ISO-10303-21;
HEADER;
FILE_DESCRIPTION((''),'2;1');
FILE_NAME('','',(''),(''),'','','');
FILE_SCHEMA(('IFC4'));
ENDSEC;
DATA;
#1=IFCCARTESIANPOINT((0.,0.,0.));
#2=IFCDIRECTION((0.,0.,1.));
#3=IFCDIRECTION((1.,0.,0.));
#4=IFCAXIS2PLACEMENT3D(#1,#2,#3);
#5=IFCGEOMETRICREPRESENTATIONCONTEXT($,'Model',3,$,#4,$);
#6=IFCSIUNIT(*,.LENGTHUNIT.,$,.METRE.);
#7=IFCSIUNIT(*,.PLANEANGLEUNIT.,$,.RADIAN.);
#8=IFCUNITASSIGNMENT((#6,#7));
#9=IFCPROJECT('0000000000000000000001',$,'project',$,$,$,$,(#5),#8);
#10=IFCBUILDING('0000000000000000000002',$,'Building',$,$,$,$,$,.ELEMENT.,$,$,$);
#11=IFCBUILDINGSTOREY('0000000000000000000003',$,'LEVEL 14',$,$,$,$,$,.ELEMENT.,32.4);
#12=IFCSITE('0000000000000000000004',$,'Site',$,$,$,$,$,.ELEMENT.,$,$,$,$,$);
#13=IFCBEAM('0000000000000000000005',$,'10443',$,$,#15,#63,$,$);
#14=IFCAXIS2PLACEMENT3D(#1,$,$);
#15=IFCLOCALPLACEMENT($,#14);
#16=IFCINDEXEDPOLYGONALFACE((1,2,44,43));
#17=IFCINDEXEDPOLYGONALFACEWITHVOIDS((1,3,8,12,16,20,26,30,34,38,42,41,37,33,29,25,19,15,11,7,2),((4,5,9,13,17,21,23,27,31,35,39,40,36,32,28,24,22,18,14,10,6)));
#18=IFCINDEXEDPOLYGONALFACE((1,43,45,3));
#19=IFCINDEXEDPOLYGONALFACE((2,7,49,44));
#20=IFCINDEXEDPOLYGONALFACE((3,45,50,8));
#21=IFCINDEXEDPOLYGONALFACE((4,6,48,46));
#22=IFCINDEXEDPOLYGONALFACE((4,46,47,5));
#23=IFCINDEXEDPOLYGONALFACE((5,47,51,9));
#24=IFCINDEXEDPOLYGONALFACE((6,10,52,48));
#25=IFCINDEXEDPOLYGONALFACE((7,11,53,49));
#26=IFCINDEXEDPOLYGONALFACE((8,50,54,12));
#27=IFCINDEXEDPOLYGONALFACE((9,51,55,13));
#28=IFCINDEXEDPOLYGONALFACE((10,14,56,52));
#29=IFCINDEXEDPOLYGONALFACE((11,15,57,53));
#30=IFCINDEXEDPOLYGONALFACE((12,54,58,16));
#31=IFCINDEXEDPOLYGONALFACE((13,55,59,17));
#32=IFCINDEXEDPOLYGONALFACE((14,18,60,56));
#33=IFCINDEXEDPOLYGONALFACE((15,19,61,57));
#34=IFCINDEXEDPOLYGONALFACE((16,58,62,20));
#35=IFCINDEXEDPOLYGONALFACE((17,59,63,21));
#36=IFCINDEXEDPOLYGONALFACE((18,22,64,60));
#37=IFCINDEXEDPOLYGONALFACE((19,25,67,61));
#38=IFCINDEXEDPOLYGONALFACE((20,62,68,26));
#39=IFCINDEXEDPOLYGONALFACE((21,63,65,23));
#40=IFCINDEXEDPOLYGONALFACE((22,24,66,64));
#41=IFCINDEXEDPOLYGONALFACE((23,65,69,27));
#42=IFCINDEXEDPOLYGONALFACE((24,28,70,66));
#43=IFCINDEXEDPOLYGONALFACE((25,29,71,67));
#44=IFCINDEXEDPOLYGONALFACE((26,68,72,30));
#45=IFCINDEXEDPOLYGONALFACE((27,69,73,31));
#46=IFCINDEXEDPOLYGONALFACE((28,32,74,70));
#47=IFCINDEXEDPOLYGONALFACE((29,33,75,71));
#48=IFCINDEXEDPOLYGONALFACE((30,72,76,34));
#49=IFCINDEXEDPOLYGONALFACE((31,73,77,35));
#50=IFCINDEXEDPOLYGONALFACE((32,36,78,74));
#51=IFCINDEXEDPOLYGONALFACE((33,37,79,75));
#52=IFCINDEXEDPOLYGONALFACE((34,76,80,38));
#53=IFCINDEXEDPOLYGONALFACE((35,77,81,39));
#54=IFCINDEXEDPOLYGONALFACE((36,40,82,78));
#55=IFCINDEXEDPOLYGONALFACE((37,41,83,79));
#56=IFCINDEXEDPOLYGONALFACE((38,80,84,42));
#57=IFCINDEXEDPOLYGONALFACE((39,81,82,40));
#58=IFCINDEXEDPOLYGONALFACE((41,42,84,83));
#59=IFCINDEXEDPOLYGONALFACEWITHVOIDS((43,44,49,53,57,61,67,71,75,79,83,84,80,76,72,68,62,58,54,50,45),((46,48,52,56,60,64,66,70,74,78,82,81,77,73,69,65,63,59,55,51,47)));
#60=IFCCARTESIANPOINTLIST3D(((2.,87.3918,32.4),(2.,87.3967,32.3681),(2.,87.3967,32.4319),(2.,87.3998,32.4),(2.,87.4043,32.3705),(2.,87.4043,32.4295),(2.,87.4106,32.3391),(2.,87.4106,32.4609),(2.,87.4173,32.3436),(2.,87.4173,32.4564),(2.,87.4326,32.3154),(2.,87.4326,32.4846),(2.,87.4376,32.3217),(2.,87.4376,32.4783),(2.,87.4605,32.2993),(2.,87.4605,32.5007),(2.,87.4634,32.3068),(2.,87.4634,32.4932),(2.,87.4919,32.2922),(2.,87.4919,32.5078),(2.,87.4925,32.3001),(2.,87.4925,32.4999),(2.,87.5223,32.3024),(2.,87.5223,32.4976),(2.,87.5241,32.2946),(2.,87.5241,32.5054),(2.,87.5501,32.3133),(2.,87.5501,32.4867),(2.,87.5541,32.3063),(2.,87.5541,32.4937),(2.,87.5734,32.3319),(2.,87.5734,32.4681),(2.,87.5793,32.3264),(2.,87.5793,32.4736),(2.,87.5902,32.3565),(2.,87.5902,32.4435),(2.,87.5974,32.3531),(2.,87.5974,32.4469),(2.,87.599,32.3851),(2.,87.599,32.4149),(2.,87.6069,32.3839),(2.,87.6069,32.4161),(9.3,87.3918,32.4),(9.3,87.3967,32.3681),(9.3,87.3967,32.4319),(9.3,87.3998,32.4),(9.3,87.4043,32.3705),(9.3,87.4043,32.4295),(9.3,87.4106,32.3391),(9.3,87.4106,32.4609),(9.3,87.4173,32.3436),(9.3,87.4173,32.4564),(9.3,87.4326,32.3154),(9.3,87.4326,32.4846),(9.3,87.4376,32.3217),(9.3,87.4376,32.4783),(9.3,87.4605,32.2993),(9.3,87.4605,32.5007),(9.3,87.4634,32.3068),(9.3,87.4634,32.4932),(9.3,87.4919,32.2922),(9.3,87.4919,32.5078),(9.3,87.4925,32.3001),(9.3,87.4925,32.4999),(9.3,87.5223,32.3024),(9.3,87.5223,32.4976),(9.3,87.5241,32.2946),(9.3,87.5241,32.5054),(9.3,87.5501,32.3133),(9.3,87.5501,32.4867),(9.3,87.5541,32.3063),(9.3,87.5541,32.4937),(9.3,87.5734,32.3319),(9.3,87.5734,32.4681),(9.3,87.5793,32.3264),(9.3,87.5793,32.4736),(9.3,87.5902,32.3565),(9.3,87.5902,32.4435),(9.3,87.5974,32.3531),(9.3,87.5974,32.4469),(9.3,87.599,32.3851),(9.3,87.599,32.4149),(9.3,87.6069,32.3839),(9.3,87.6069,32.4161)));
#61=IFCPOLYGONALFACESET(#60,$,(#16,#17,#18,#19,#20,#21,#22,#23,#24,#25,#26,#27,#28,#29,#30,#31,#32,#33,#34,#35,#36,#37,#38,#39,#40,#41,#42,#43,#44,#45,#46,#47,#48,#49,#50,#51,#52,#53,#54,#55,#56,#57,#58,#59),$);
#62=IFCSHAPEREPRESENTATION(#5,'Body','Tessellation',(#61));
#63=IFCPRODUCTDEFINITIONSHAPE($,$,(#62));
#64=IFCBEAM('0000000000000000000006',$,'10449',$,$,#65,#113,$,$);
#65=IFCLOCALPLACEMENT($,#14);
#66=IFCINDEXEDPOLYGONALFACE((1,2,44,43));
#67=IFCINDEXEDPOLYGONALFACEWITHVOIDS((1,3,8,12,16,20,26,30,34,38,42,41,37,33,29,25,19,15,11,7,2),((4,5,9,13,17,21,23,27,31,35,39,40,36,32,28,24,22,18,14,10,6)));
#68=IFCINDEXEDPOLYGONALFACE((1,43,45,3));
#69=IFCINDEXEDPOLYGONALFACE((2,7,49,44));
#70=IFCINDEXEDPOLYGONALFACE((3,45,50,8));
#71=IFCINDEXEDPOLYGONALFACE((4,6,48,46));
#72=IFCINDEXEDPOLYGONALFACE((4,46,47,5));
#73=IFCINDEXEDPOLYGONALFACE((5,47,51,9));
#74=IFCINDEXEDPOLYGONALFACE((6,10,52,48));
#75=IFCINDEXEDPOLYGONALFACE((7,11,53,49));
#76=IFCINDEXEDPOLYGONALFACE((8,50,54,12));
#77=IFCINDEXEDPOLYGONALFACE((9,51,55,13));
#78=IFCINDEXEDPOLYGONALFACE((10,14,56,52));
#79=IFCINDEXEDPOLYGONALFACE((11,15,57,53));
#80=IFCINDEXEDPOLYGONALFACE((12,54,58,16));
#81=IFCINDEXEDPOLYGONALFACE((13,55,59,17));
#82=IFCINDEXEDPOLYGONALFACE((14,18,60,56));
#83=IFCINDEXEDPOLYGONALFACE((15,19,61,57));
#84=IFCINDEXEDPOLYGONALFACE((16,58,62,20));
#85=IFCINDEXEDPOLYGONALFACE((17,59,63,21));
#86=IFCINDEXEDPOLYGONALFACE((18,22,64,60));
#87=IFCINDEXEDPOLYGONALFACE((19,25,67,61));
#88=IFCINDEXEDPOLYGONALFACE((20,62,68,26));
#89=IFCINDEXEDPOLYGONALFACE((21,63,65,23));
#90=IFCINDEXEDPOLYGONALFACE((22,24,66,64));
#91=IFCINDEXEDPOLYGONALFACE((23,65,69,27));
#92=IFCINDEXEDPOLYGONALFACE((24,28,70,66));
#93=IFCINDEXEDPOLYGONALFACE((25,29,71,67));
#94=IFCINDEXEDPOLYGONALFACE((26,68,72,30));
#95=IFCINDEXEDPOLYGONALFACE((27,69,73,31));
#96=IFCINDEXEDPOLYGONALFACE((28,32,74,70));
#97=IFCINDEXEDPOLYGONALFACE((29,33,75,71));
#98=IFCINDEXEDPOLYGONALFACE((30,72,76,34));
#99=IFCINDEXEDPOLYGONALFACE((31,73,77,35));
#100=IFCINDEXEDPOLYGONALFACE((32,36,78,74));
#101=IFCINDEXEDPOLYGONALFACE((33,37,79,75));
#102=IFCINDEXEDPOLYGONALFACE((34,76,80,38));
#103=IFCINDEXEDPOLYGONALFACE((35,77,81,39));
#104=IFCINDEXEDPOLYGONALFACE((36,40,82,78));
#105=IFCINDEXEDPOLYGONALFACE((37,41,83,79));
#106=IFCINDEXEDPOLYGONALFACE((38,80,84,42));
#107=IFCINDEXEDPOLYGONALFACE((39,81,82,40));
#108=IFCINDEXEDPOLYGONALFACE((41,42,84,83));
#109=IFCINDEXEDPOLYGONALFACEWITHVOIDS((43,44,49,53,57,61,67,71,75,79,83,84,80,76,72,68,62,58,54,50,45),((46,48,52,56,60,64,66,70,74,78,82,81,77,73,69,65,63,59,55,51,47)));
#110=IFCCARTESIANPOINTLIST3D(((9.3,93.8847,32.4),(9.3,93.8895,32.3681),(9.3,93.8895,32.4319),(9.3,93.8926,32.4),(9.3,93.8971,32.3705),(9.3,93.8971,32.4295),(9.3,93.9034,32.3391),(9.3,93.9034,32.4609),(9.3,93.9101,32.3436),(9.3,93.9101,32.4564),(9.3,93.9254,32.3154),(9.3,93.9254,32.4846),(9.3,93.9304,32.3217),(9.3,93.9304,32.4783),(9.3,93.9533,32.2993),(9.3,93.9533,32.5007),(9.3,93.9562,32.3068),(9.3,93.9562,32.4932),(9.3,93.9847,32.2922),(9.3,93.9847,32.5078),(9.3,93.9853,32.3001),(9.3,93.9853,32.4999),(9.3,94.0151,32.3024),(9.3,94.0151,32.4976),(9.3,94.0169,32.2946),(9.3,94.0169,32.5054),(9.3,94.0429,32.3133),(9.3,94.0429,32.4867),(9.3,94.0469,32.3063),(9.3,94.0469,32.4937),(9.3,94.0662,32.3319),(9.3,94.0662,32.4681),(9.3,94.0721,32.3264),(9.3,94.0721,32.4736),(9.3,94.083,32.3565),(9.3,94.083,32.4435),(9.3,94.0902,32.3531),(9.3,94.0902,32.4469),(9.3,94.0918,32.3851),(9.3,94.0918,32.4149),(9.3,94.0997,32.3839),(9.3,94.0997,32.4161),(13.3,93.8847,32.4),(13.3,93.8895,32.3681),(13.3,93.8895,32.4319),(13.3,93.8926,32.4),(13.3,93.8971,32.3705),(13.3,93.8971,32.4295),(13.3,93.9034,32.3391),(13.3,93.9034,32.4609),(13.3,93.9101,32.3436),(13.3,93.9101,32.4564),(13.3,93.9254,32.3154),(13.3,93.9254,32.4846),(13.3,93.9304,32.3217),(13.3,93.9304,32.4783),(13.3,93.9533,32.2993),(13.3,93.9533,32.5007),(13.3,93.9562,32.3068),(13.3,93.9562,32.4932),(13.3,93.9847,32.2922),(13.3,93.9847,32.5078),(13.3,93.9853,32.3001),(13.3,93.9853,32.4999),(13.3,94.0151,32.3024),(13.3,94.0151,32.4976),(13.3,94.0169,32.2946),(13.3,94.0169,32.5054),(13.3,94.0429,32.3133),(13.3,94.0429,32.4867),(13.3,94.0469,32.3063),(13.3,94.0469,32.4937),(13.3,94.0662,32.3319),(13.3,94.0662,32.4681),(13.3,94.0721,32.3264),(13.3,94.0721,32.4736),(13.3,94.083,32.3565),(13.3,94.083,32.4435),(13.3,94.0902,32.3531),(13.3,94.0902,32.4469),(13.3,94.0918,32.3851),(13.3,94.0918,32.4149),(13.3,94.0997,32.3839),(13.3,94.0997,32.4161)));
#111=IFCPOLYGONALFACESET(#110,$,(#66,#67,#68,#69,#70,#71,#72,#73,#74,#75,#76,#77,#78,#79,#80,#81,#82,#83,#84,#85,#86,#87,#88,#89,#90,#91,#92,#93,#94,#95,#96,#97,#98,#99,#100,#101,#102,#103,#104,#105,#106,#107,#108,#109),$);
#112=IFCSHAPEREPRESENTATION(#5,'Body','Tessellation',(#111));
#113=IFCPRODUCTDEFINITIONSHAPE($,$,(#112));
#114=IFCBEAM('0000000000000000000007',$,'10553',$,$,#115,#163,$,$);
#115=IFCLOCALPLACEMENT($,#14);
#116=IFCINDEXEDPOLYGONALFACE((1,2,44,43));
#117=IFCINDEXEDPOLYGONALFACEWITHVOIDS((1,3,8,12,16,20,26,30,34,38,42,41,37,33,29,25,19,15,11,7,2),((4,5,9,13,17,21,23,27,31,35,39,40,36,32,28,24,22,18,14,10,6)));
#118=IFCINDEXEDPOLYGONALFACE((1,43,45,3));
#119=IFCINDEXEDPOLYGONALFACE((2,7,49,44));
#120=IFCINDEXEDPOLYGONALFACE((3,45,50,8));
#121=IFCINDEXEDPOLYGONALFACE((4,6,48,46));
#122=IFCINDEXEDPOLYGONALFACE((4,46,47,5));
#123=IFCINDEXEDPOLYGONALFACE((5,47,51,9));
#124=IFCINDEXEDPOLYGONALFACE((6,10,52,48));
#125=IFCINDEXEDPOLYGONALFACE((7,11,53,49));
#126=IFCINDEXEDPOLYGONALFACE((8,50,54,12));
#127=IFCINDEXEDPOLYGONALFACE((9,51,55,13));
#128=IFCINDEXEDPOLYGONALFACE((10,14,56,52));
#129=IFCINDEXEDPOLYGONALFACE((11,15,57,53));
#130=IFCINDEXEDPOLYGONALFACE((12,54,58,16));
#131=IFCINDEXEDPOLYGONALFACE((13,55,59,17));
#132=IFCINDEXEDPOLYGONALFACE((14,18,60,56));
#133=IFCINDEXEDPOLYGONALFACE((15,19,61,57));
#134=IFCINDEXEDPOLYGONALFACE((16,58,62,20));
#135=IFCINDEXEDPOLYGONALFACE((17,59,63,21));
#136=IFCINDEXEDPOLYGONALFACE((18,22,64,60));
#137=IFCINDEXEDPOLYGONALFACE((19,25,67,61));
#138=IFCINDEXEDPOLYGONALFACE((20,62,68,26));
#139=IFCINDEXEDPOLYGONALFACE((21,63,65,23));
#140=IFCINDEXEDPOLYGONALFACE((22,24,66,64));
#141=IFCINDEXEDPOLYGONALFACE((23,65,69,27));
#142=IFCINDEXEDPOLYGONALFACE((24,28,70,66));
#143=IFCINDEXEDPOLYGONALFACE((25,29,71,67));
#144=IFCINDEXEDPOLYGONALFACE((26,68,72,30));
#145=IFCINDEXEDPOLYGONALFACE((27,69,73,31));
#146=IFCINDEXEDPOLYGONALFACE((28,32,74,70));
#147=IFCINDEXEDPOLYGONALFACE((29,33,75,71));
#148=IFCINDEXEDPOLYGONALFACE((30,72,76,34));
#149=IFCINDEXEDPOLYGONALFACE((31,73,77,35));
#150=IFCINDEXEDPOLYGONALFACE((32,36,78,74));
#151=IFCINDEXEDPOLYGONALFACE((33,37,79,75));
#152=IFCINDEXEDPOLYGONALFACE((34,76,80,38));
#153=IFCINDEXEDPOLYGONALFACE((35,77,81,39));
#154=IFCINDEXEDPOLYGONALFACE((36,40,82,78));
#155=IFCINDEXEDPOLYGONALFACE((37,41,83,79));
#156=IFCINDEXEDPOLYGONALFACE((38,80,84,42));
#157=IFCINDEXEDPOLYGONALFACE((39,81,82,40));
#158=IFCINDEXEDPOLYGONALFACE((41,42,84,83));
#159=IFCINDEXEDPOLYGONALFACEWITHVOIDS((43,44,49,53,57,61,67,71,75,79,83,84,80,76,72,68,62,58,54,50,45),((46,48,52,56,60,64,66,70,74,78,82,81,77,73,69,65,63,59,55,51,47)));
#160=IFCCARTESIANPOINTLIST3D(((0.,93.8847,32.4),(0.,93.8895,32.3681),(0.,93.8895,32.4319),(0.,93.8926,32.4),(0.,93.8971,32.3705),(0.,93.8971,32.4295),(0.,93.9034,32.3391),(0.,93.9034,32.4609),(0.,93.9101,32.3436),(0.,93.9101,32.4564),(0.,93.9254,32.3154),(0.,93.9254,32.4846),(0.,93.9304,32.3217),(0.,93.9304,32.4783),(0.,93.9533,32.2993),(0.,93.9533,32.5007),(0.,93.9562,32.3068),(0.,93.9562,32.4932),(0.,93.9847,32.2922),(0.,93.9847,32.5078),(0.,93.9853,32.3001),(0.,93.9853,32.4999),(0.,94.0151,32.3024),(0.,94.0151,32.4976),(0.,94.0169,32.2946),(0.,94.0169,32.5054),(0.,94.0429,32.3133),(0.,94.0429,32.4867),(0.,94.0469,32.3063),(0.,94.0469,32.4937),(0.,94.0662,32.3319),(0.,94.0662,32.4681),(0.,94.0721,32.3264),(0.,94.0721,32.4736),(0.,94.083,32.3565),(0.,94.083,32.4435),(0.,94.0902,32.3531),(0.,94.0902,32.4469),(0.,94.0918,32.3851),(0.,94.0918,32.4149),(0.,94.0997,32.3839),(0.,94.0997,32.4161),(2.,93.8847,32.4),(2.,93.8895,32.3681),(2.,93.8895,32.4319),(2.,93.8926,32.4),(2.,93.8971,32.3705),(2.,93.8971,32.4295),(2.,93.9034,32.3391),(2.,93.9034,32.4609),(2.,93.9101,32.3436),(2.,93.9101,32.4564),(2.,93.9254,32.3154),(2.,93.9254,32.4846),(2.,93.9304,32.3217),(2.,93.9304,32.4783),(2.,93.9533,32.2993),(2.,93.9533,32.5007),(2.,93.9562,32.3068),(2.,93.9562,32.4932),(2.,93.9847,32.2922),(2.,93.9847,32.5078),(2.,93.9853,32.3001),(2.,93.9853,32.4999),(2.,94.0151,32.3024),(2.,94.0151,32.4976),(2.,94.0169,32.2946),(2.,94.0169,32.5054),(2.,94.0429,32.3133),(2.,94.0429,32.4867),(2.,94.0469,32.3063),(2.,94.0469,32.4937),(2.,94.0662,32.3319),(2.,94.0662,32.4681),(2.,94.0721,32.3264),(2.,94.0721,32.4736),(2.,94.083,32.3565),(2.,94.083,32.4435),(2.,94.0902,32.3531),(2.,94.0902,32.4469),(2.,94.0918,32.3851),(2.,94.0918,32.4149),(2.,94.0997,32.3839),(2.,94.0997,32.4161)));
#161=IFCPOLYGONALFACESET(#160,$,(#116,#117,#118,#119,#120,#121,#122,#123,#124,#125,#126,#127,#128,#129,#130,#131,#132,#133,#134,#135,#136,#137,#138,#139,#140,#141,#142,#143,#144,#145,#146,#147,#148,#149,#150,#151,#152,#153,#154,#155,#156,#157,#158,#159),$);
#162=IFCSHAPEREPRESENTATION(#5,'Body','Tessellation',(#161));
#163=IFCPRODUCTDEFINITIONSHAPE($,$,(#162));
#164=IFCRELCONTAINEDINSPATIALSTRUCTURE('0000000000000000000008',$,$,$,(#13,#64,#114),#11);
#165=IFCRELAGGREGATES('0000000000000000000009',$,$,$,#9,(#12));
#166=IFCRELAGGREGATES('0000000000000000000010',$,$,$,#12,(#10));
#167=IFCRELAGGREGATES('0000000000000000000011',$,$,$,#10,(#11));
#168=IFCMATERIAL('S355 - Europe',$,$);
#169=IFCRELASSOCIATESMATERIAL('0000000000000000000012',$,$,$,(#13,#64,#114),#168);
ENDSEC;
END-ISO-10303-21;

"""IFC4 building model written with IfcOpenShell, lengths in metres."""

from ifc_helpers import new_model, si_unit, frame, origin_with_axes, origin_2d_with_axis, place, context, project, spatial, hollow_circle, extrude, material, material_profile, profile_set, profile_usage, element, save


model = new_model("IFC4")

# Units and contexts
model_context = context("Model", 3, world=origin_with_axes())
ifc_project = project(units=[si_unit("LENGTHUNIT", "METRE"), si_unit("PLANEANGLEUNIT", "RADIAN")], contexts=[model_context])

# Site, building, storey
site = spatial("IfcSite", under=ifc_project, Name="Site", CompositionType="ELEMENT")
building = spatial("IfcBuilding", under=site, Name="Building", CompositionType="ELEMENT")
storey = spatial("IfcBuildingStorey", under=building, Name="LEVEL 14", CompositionType="ELEMENT", Elevation=32.4)

# Shared definitions
ifc_material = material(Name="S355 - Europe")

# Beams
ifc_material_profile_1 = material_profile(ifc_material, hollow_circle(Radius=0.1081, WallThickness=0.008, at=origin_2d_with_axis()))
ifc_profile_set_1 = profile_set([ifc_material_profile_1])
ifc_profile_usage_1 = profile_usage(ifc_profile_set_1, cardinal=10)
beam_1_placement = place(None, frame((9.3, 87.5, 32.4), z_axis=(-1.0, 0.0, 0.0), x_axis=(0.0, -1.0, 0.0)))
element("IfcBeam", 1, at=beam_1_placement, inside=storey, material=ifc_profile_usage_1, Name="10443", context=model_context, shape_type="SweptSolid", body=[
    extrude(hollow_circle(Radius=0.1081, WallThickness=0.008, at=origin_2d_with_axis()), origin_with_axes(), (0.0, 0.0, 1.0), 7.3),
])
ifc_material_profile_2 = material_profile(ifc_material, hollow_circle(Radius=0.1081, WallThickness=0.008, at=origin_2d_with_axis()))
ifc_profile_set_2 = profile_set([ifc_material_profile_2])
ifc_profile_usage_2 = profile_usage(ifc_profile_set_2, cardinal=10)
beam_2_placement = place(None, frame((13.3, 93.9928, 32.4), z_axis=(-1.0, 0.0, 0.0), x_axis=(0.0, -1.0, 0.0)))
element("IfcBeam", 2, at=beam_2_placement, inside=storey, material=ifc_profile_usage_2, Name="10449", context=model_context, shape_type="SweptSolid", body=[
    extrude(hollow_circle(Radius=0.1081, WallThickness=0.008, at=origin_2d_with_axis()), origin_with_axes(), (0.0, 0.0, 1.0), 4.0),
])
ifc_material_profile_3 = material_profile(ifc_material, hollow_circle(Radius=0.1081, WallThickness=0.008, at=origin_2d_with_axis()))
ifc_profile_set_3 = profile_set([ifc_material_profile_3])
ifc_profile_usage_3 = profile_usage(ifc_profile_set_3, cardinal=10)
beam_3_placement = place(None, frame((2.0, 93.9928, 32.4), z_axis=(-1.0, 0.0, 0.0), x_axis=(0.0, -1.0, 0.0)))
element("IfcBeam", 3, at=beam_3_placement, inside=storey, material=ifc_profile_usage_3, Name="10553", context=model_context, shape_type="SweptSolid", body=[
    extrude(hollow_circle(Radius=0.1081, WallThickness=0.008, at=origin_2d_with_axis()), origin_with_axes(), (0.0, 0.0, 1.0), 2.0),
])

save(model, "model.ifc")
